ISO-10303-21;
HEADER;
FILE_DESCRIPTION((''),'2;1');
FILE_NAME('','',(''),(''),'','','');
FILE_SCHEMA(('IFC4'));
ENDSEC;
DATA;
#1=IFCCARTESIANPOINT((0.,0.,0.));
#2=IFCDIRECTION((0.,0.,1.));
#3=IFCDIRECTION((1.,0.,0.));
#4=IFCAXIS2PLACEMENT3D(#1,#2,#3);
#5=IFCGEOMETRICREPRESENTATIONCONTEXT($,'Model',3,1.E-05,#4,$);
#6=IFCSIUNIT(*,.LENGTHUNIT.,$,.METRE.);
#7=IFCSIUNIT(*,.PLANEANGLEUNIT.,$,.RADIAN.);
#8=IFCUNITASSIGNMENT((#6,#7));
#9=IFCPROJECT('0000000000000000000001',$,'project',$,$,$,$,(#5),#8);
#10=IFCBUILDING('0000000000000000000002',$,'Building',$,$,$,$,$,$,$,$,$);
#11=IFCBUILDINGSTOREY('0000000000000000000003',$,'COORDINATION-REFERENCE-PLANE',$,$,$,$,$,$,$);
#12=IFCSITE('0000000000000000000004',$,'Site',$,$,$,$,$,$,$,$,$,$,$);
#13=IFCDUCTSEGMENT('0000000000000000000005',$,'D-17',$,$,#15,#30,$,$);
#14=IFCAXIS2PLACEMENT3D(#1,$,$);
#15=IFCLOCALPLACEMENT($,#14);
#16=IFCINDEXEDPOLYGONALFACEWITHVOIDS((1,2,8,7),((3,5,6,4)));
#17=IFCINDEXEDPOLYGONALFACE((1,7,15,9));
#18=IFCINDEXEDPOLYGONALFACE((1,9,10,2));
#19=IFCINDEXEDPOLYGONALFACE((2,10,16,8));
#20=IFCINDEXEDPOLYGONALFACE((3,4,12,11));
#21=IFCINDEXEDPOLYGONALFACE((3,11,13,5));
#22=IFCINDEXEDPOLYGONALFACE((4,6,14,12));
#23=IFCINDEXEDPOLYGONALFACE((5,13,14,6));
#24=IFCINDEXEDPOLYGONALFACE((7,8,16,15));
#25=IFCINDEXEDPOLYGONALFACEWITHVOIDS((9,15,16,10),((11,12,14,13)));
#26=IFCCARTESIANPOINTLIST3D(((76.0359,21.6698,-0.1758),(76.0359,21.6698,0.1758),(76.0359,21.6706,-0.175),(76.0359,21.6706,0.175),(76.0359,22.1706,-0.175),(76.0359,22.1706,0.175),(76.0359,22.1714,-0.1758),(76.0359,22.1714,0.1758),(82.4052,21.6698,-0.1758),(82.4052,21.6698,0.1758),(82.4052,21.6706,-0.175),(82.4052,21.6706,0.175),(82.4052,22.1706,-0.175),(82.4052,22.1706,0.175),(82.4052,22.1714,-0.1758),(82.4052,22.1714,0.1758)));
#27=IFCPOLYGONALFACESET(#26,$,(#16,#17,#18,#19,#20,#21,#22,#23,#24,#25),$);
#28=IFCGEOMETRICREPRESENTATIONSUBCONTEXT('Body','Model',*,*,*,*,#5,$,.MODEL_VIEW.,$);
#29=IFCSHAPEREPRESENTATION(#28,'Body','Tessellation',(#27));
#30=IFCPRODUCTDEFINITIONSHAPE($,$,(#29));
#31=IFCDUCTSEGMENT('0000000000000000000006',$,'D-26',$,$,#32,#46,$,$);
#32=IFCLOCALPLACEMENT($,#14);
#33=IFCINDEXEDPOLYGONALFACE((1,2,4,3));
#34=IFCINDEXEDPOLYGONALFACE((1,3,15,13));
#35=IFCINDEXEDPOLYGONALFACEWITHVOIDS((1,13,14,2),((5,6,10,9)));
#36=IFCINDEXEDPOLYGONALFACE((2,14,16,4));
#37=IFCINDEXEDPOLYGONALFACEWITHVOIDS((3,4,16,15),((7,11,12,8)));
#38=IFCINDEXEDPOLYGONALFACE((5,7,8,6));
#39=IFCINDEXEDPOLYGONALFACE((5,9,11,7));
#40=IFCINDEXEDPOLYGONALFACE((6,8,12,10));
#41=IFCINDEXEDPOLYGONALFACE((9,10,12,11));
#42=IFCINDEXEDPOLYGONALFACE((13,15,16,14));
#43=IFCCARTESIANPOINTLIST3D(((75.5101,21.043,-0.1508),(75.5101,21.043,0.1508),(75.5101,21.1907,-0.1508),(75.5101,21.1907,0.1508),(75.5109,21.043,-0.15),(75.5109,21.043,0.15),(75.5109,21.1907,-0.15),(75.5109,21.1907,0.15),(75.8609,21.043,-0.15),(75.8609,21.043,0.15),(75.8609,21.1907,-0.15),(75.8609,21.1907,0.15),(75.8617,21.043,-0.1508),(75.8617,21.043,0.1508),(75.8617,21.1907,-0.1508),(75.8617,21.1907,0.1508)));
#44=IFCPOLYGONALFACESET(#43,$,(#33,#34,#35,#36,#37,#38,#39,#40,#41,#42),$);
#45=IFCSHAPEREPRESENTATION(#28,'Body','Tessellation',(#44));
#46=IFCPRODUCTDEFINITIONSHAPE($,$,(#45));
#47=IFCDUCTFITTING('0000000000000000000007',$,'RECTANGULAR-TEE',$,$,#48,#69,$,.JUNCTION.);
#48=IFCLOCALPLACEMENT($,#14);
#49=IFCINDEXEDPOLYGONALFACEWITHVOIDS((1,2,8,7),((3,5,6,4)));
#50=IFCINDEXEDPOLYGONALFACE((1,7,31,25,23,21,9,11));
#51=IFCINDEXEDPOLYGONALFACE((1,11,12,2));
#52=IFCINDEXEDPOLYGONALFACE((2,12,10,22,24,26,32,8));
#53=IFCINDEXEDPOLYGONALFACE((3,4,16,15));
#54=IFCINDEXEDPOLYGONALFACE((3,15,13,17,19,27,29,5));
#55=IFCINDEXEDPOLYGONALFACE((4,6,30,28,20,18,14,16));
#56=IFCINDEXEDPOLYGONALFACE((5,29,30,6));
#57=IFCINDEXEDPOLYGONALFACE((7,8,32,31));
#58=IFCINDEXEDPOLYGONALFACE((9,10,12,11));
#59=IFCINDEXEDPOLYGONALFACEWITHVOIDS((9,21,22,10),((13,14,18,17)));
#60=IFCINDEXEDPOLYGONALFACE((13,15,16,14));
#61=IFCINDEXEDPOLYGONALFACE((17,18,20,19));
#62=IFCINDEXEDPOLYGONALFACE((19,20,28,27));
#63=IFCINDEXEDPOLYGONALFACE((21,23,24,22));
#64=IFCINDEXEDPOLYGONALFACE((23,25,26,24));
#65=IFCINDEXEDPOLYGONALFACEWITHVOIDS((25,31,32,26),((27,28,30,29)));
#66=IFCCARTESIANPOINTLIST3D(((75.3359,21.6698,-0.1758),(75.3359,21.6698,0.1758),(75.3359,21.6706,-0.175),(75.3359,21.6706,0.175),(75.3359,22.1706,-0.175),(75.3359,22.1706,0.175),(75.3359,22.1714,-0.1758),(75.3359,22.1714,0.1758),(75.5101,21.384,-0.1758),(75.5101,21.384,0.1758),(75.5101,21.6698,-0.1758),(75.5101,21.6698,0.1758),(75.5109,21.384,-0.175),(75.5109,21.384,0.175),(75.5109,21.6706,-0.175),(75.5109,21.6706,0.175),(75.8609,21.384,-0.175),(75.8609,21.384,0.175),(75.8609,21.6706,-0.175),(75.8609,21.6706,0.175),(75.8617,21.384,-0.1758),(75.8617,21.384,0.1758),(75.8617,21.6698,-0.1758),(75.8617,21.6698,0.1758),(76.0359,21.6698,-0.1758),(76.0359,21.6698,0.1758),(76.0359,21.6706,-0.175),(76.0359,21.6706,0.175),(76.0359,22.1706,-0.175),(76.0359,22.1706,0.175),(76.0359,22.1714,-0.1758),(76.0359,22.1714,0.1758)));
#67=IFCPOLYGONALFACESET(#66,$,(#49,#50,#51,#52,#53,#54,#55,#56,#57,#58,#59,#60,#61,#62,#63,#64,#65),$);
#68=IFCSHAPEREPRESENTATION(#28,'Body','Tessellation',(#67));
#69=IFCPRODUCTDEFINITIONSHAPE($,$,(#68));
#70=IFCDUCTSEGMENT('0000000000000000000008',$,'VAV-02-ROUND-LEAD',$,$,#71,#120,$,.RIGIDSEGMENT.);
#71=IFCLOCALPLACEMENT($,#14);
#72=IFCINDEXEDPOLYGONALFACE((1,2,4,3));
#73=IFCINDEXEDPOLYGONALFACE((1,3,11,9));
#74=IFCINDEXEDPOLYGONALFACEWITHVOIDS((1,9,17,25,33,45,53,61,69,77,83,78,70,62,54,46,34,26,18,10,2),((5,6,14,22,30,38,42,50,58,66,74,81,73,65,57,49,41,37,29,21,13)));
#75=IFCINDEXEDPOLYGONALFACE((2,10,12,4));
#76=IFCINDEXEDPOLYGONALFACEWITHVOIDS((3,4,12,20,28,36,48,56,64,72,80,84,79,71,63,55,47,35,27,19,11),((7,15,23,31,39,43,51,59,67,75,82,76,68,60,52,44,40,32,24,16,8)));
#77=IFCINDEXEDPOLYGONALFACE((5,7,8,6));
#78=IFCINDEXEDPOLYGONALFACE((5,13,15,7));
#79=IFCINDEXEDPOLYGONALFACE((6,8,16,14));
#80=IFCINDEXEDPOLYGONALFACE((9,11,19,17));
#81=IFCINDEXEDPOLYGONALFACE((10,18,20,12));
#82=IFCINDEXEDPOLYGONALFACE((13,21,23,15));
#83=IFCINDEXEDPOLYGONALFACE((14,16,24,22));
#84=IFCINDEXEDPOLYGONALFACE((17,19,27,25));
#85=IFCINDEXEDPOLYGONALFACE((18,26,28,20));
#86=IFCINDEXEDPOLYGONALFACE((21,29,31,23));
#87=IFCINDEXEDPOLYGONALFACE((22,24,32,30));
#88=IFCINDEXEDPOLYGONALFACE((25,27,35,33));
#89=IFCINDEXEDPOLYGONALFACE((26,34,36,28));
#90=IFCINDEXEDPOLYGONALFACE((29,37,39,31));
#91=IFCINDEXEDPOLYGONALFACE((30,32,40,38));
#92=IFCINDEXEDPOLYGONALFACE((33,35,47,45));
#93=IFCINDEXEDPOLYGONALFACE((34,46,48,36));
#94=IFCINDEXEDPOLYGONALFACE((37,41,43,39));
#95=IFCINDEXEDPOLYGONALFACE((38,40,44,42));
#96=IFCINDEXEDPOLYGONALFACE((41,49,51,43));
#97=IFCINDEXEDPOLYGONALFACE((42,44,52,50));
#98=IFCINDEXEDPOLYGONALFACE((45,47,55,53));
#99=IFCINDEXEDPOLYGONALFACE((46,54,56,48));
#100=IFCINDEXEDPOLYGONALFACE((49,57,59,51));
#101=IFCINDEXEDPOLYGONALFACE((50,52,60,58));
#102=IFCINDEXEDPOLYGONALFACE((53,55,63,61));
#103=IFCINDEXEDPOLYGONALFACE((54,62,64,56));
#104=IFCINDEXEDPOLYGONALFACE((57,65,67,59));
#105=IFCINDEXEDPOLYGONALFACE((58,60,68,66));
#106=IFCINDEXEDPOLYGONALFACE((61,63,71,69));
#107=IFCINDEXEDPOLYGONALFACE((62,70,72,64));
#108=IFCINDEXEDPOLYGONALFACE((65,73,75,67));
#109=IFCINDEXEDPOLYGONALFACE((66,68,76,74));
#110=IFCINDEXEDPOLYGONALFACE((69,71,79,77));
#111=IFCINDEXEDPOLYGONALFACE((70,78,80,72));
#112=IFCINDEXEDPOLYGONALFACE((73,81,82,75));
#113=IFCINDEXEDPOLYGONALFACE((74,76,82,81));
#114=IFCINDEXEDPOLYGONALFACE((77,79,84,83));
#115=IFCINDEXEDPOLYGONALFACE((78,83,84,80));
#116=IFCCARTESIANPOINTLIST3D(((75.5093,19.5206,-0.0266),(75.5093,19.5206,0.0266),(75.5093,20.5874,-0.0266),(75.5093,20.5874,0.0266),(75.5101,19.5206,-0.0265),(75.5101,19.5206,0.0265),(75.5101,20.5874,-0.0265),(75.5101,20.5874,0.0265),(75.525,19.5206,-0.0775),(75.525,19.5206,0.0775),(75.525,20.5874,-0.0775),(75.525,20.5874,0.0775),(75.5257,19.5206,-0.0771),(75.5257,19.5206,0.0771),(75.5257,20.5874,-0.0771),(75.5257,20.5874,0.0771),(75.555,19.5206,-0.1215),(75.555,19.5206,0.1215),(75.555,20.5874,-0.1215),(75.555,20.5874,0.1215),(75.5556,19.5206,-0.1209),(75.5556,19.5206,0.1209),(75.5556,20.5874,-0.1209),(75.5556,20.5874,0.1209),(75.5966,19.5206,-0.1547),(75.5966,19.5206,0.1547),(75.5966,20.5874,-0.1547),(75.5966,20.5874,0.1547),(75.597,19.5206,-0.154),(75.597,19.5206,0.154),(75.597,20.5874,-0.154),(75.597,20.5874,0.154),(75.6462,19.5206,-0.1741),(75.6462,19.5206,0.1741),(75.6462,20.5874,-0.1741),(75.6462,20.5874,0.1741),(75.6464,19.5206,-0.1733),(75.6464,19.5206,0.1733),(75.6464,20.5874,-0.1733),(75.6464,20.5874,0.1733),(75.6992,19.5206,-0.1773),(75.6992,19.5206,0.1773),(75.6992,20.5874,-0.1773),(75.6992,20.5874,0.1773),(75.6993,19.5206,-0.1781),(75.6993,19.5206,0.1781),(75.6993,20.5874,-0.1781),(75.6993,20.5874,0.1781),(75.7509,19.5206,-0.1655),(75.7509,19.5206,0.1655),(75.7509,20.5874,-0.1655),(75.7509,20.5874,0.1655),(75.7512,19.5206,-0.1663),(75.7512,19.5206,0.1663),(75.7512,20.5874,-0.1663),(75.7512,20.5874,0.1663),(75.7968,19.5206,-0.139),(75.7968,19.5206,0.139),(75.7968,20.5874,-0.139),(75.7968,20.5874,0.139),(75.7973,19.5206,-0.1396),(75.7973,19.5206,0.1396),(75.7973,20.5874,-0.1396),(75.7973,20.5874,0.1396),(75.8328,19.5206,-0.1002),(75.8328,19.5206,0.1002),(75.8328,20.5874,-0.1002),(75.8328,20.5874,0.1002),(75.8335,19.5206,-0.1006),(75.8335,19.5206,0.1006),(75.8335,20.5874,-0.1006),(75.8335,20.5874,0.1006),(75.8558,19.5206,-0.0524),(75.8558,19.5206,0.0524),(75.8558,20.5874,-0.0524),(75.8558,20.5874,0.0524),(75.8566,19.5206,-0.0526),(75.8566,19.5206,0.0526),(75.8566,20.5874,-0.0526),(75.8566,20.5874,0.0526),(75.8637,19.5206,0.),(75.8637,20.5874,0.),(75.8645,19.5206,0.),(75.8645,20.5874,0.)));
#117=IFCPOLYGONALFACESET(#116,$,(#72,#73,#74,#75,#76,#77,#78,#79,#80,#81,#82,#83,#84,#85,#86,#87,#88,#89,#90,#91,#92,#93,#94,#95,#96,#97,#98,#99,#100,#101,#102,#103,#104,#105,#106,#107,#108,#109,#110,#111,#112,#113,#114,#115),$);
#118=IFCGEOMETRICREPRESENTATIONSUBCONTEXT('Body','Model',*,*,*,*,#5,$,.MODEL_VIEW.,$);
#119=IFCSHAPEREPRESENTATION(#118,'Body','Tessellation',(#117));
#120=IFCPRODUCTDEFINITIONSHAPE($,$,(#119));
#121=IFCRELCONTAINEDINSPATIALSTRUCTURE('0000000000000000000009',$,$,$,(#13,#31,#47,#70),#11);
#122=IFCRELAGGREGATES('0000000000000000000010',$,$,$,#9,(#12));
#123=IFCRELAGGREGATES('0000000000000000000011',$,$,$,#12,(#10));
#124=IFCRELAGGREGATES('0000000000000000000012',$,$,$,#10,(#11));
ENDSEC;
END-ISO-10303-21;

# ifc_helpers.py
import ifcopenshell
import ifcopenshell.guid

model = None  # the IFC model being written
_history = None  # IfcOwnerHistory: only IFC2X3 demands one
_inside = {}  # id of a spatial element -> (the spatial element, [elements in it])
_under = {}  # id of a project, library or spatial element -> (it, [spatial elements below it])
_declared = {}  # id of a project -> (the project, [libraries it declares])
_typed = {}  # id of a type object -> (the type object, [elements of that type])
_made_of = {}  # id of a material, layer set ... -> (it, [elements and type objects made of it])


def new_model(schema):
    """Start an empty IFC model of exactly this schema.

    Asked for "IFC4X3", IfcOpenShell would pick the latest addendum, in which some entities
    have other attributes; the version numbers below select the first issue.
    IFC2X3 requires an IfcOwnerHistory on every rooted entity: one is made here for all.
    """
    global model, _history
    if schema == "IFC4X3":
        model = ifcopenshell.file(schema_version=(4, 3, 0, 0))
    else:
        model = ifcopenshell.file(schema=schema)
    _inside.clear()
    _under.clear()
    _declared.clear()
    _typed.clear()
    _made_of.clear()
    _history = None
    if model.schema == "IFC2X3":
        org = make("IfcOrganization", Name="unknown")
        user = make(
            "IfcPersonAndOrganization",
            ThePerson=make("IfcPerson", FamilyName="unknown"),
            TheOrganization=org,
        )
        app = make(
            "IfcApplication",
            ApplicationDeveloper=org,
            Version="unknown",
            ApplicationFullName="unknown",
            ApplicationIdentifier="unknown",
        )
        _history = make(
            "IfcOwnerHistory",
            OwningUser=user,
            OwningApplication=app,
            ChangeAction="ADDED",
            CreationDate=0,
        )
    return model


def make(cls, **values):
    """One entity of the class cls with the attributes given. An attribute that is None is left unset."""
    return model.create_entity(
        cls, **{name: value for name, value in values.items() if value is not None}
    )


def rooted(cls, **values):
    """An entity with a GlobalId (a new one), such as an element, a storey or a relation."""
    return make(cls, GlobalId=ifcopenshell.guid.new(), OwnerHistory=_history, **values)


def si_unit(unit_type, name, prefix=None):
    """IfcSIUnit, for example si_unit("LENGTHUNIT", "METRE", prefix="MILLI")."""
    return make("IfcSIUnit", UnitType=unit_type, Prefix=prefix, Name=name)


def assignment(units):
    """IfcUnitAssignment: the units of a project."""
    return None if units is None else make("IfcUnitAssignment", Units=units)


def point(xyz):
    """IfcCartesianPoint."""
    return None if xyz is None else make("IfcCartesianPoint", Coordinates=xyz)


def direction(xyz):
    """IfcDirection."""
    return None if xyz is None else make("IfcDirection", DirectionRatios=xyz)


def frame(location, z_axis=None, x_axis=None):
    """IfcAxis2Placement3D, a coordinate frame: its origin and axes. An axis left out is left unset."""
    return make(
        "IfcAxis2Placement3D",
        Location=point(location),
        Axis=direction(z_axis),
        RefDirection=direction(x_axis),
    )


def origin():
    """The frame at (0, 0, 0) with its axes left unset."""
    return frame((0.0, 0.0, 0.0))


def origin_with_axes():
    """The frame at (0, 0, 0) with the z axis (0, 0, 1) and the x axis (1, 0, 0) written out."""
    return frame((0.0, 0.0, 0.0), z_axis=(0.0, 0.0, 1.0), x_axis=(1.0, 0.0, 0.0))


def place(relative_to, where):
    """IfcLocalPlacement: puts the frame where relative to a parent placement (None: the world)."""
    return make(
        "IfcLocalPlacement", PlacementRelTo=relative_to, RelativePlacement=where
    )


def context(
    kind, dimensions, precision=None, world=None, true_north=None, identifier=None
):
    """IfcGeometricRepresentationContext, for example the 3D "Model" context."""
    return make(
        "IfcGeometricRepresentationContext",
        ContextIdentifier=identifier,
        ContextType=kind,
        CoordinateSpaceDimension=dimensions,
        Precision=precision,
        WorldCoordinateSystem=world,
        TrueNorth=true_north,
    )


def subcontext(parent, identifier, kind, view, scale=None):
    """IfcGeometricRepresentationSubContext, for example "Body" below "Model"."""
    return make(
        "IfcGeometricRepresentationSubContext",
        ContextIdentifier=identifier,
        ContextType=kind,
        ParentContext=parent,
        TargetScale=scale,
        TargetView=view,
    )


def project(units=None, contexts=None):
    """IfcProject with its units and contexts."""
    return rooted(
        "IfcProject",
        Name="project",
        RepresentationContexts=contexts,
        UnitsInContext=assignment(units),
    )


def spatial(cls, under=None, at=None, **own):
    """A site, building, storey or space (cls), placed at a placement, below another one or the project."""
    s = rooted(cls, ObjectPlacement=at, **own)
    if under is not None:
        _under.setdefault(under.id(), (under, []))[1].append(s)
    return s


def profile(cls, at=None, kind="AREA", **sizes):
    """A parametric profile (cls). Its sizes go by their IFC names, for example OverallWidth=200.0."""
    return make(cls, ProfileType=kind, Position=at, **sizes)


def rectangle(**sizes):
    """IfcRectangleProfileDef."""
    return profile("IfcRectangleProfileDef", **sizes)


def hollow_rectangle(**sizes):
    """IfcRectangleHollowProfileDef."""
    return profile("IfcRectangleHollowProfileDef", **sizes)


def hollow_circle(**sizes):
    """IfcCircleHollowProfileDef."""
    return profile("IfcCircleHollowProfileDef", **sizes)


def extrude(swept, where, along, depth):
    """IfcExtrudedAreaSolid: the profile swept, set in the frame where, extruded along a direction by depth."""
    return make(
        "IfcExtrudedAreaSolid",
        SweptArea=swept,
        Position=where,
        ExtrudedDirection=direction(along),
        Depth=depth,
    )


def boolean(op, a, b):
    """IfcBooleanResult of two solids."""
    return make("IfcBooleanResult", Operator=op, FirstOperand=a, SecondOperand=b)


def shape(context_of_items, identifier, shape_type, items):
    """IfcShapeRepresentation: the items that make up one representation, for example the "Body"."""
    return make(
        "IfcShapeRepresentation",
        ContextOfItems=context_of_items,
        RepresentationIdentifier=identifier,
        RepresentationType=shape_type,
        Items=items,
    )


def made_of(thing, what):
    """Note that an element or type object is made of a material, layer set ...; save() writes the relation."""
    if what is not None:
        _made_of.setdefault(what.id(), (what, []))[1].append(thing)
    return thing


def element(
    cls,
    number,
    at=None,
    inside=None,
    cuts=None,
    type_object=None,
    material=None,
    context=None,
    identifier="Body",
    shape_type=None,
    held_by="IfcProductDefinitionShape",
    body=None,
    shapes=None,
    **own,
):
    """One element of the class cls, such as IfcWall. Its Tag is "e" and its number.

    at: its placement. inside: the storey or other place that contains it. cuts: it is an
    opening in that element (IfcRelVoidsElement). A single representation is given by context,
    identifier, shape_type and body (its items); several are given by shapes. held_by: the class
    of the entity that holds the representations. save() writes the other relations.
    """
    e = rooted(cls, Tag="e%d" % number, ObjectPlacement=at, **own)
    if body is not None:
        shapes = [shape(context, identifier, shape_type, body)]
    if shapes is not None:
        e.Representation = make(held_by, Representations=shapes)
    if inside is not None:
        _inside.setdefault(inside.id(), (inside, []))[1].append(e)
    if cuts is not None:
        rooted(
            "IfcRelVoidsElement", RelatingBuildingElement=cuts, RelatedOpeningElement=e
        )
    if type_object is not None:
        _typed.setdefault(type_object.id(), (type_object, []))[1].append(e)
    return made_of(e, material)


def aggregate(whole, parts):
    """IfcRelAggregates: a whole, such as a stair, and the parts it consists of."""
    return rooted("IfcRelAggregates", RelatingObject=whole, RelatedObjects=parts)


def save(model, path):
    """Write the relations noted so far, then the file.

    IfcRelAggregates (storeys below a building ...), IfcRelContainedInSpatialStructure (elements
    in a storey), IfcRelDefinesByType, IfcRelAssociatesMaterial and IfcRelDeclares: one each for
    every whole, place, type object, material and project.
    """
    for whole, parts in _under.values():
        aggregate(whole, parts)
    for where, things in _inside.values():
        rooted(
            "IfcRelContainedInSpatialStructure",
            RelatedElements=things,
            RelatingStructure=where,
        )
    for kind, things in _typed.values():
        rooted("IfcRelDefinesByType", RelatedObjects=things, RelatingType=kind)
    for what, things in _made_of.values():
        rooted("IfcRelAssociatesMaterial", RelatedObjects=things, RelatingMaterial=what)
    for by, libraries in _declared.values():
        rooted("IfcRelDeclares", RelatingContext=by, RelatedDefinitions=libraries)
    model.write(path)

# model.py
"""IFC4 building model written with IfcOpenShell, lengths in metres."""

from ifc_helpers import new_model, si_unit, frame, origin, origin_with_axes, place, context, subcontext, project, spatial, rectangle, hollow_rectangle, hollow_circle, extrude, boolean, element, save


model = new_model("IFC4")

# Units and contexts
model_context = context("Model", 3, precision=1e-05, world=origin_with_axes())
body_context_1 = subcontext(model_context, "Body", "Model", "MODEL_VIEW")
body_context_2 = subcontext(model_context, "Body", "Model", "MODEL_VIEW")
ifc_project = project(units=[si_unit("LENGTHUNIT", "METRE"), si_unit("PLANEANGLEUNIT", "RADIAN")], contexts=[model_context])

# Site, building, storey
site = spatial("IfcSite", under=ifc_project, Name="Site")
building = spatial("IfcBuilding", under=site, Name="Building")
storey = spatial("IfcBuildingStorey", under=building, Name="COORDINATION-REFERENCE-PLANE")

# Duct segments
duct_segment_1_placement = place(None, frame((76.0359, 21.9206, 0.0), z_axis=(1.0, 0.0, 0.0), x_axis=(0.0, 1.0, 0.0)))
element("IfcDuctSegment", 1, at=duct_segment_1_placement, inside=storey, Name="D-17", context=body_context_1, shape_type="SweptSolid", body=[
    extrude(hollow_rectangle(XDim=0.5016, YDim=0.3516, WallThickness=0.0008), origin(), (0.0, 0.0, 1.0), 6.3693),
])
duct_segment_2_placement = place(None, frame((75.6859, 21.043, 0.0), z_axis=(0.0, 1.0, 0.0), x_axis=(1.0, 0.0, 0.0)))
element("IfcDuctSegment", 2, at=duct_segment_2_placement, inside=storey, Name="D-26", context=body_context_1, shape_type="SweptSolid", body=[
    extrude(hollow_rectangle(XDim=0.3516, YDim=0.3016, WallThickness=0.0008), origin(), (0.0, 0.0, 1.0), 0.1477),
])

# Duct fitting
duct_fitting_1_placement = place(None, frame((75.6859, 21.9206, 0.0), z_axis=(-1.0, 0.0, 0.0), x_axis=(0.0, -1.0, 0.0)))
solid = boolean("UNION", extrude(rectangle(XDim=0.5, YDim=0.35), frame((0.0, 0.0, -0.35), z_axis=(0.0, 0.0, 1.0), x_axis=(1.0, 0.0, 0.0)), (0.0, 0.0, 1.0), 0.7), extrude(rectangle(XDim=0.35, YDim=0.35), frame((0.0, 0.0, 0.0), z_axis=(1.0, 0.0, 0.0), x_axis=(0.0, 0.0, -1.0)), (0.0, 0.0, 1.0), 0.5366))
element("IfcDuctFitting", 3, at=duct_fitting_1_placement, inside=storey, Name="RECTANGULAR-TEE", PredefinedType="JUNCTION", context=body_context_1, shape_type="CSG", body=[
    boolean("DIFFERENCE", boolean("UNION", extrude(rectangle(XDim=0.5016, YDim=0.3516), frame((0.0, 0.0, -0.35), z_axis=(0.0, 0.0, 1.0), x_axis=(1.0, 0.0, 0.0)), (0.0, 0.0, 1.0), 0.7), extrude(rectangle(XDim=0.3516, YDim=0.3516), frame((0.0, 0.0, 0.0), z_axis=(1.0, 0.0, 0.0), x_axis=(0.0, 0.0, -1.0)), (0.0, 0.0, 1.0), 0.5366)), solid),
])

# Duct segment
duct_segment_3_placement = place(None, frame((75.6859, 20.5874, 0.0), z_axis=(0.0, -1.0, 0.0), x_axis=(1.0, 0.0, 0.0)))
element("IfcDuctSegment", 4, at=duct_segment_3_placement, inside=storey, Name="VAV-02-ROUND-LEAD", PredefinedType="RIGIDSEGMENT", context=body_context_2, shape_type="SweptSolid", body=[
    extrude(hollow_circle(Radius=0.1786, WallThickness=0.0008), origin(), (0.0, 0.0, 1.0), 1.0668),
])

save(model, "model.ifc")
